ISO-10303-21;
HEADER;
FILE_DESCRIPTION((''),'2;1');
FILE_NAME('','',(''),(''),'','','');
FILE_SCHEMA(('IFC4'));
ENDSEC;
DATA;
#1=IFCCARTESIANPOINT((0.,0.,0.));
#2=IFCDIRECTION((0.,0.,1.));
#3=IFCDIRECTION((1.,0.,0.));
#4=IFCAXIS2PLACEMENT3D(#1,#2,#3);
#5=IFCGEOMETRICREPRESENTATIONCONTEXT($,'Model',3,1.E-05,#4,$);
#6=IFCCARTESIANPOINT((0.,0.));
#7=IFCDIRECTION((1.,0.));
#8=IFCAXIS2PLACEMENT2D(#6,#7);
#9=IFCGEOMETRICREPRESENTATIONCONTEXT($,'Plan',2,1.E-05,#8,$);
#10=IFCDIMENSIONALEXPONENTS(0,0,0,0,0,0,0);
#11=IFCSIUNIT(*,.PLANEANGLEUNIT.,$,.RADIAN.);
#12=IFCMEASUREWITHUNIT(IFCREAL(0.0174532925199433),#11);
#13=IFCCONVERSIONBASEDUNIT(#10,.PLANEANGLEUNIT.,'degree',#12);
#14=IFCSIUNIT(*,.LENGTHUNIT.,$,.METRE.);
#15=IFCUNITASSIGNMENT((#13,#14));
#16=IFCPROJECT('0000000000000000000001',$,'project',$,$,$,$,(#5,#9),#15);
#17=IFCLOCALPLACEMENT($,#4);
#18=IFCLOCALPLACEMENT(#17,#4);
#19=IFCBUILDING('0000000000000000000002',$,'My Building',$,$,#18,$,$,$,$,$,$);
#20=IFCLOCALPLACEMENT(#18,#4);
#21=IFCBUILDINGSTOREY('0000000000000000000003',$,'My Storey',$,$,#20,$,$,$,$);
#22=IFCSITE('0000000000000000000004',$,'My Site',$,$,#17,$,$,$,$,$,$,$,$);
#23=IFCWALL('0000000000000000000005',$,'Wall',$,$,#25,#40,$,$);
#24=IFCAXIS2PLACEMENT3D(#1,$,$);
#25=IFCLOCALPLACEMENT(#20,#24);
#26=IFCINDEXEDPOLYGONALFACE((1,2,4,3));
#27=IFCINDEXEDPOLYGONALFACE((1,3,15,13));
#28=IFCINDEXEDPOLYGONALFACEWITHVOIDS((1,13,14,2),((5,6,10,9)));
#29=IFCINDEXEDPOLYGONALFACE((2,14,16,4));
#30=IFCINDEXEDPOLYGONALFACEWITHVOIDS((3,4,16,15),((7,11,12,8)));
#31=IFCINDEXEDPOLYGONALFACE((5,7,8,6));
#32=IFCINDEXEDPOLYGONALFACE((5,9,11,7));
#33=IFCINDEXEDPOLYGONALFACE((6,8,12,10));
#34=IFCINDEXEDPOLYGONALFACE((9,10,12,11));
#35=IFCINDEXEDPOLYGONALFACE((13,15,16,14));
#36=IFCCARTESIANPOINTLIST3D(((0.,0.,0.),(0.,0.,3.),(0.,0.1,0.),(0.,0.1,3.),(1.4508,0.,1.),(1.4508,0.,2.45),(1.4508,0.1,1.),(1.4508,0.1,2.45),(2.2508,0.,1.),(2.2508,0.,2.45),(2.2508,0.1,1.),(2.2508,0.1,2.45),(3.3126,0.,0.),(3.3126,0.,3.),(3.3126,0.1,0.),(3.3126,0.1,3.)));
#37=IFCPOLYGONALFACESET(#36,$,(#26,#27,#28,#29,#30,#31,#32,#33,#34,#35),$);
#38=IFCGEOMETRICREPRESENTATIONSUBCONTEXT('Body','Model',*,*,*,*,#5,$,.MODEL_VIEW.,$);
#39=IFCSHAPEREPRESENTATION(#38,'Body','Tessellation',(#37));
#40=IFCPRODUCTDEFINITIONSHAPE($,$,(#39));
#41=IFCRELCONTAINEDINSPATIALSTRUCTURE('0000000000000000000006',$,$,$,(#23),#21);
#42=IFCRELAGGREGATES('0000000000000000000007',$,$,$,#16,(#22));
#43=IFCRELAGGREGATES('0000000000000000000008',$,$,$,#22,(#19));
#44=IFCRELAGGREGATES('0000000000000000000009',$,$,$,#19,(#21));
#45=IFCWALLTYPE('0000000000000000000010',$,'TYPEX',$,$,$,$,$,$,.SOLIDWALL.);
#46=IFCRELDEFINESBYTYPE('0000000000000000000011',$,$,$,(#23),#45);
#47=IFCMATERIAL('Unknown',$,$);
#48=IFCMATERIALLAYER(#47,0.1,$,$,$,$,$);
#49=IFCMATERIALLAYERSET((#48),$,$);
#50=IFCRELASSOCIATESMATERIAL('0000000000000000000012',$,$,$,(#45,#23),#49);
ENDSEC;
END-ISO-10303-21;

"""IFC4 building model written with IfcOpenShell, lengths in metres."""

from ifc_helpers import new_model, entity, si_unit, converted_unit, frame, origin_with_axes, origin_2d_with_axis, place, context, subcontext, project, spatial, line, indexed_curve, outline, extrude, source, transform, mapped, material, layer, layer_set, layer_usage, type_object, element, save


model = new_model("IFC4")

# Units and contexts
model_context = context("Model", 3, precision=1e-05, world=origin_with_axes())
plan_context = context("Plan", 2, precision=1e-05, world=origin_2d_with_axis())
body_context = subcontext(model_context, "Body", "Model", "MODEL_VIEW")
ifc_project = project(units=[converted_unit("PLANEANGLEUNIT", "degree", entity("IfcReal", 0.0174532925199433), si_unit("PLANEANGLEUNIT", "RADIAN"), dimensions=[0, 0, 0, 0, 0, 0, 0]), si_unit("LENGTHUNIT", "METRE")], contexts=[model_context, plan_context])

# Site, building, storey
site_placement = place(None, origin_with_axes())
site = spatial("IfcSite", under=ifc_project, at=site_placement, Name="My Site")
building_placement = place(site_placement, origin_with_axes())
building = spatial("IfcBuilding", under=site, at=building_placement, Name="My Building")
storey_placement = place(building_placement, origin_with_axes())
storey = spatial("IfcBuildingStorey", under=building, at=storey_placement, Name="My Storey")

# Wall, opening
ifc_material = material(Name="Unknown")
ifc_layer = layer(ifc_material, 0.1)
ifc_layer_set = layer_set([ifc_layer])
ifc_layer_usage = layer_usage(ifc_layer_set, "AXIS2", "POSITIVE", 0.0)
wall_type = type_object("IfcWallType", Name="TYPEX", PredefinedType="SOLIDWALL", material=ifc_layer_set)
wall_placement = place(storey_placement, origin_with_axes())
wall = element("IfcWall", 1, at=wall_placement, inside=storey, type_object=wall_type, material=ifc_layer_usage, Name="Wall", context=body_context, shape_type="SweptSolid", body=[
    extrude(outline(indexed_curve([(0.0, 0.0), (0.0, 0.1), (3.3126, 0.1), (3.3126, 0.0), (0.0, 0.0)], self_intersect=False)), origin_with_axes(), (0.0, 0.0, 1.0), 3.0),
])
shared_shape = source(origin_with_axes(), body_context, "Body", "SweptSolid", [
    extrude(outline(indexed_curve([(0.0, 0.0), (0.8, 0.0), (0.8, 1.45), (0.0, 1.45)], segments=[line(1, 2, 3, 4, 1)])), frame((0.0, -0.6, 0.0), z_axis=(0.0, -1.0, 0.0), x_axis=(1.0, 0.0, 0.0)), (0.0, 0.0, -1.0), 1.2),
])
opening_placement = place(wall_placement, frame((1.4508, 0.0, 1.0), z_axis=(0.0, 0.0, 1.0), x_axis=(1.0, 0.0, 0.0)))
element("IfcOpeningElement", 2, at=opening_placement, cuts=wall, PredefinedType="OPENING", context=body_context, shape_type="MappedRepresentation", body=[
    mapped(shared_shape, transform((0.0, 0.0, 0.0), x_axis=(1.0, 0.0, 0.0), y_axis=(0.0, 1.0, 0.0), z_axis=(0.0, 0.0, 1.0), scale=1.0)),
])

save(model, "model.ifc")
